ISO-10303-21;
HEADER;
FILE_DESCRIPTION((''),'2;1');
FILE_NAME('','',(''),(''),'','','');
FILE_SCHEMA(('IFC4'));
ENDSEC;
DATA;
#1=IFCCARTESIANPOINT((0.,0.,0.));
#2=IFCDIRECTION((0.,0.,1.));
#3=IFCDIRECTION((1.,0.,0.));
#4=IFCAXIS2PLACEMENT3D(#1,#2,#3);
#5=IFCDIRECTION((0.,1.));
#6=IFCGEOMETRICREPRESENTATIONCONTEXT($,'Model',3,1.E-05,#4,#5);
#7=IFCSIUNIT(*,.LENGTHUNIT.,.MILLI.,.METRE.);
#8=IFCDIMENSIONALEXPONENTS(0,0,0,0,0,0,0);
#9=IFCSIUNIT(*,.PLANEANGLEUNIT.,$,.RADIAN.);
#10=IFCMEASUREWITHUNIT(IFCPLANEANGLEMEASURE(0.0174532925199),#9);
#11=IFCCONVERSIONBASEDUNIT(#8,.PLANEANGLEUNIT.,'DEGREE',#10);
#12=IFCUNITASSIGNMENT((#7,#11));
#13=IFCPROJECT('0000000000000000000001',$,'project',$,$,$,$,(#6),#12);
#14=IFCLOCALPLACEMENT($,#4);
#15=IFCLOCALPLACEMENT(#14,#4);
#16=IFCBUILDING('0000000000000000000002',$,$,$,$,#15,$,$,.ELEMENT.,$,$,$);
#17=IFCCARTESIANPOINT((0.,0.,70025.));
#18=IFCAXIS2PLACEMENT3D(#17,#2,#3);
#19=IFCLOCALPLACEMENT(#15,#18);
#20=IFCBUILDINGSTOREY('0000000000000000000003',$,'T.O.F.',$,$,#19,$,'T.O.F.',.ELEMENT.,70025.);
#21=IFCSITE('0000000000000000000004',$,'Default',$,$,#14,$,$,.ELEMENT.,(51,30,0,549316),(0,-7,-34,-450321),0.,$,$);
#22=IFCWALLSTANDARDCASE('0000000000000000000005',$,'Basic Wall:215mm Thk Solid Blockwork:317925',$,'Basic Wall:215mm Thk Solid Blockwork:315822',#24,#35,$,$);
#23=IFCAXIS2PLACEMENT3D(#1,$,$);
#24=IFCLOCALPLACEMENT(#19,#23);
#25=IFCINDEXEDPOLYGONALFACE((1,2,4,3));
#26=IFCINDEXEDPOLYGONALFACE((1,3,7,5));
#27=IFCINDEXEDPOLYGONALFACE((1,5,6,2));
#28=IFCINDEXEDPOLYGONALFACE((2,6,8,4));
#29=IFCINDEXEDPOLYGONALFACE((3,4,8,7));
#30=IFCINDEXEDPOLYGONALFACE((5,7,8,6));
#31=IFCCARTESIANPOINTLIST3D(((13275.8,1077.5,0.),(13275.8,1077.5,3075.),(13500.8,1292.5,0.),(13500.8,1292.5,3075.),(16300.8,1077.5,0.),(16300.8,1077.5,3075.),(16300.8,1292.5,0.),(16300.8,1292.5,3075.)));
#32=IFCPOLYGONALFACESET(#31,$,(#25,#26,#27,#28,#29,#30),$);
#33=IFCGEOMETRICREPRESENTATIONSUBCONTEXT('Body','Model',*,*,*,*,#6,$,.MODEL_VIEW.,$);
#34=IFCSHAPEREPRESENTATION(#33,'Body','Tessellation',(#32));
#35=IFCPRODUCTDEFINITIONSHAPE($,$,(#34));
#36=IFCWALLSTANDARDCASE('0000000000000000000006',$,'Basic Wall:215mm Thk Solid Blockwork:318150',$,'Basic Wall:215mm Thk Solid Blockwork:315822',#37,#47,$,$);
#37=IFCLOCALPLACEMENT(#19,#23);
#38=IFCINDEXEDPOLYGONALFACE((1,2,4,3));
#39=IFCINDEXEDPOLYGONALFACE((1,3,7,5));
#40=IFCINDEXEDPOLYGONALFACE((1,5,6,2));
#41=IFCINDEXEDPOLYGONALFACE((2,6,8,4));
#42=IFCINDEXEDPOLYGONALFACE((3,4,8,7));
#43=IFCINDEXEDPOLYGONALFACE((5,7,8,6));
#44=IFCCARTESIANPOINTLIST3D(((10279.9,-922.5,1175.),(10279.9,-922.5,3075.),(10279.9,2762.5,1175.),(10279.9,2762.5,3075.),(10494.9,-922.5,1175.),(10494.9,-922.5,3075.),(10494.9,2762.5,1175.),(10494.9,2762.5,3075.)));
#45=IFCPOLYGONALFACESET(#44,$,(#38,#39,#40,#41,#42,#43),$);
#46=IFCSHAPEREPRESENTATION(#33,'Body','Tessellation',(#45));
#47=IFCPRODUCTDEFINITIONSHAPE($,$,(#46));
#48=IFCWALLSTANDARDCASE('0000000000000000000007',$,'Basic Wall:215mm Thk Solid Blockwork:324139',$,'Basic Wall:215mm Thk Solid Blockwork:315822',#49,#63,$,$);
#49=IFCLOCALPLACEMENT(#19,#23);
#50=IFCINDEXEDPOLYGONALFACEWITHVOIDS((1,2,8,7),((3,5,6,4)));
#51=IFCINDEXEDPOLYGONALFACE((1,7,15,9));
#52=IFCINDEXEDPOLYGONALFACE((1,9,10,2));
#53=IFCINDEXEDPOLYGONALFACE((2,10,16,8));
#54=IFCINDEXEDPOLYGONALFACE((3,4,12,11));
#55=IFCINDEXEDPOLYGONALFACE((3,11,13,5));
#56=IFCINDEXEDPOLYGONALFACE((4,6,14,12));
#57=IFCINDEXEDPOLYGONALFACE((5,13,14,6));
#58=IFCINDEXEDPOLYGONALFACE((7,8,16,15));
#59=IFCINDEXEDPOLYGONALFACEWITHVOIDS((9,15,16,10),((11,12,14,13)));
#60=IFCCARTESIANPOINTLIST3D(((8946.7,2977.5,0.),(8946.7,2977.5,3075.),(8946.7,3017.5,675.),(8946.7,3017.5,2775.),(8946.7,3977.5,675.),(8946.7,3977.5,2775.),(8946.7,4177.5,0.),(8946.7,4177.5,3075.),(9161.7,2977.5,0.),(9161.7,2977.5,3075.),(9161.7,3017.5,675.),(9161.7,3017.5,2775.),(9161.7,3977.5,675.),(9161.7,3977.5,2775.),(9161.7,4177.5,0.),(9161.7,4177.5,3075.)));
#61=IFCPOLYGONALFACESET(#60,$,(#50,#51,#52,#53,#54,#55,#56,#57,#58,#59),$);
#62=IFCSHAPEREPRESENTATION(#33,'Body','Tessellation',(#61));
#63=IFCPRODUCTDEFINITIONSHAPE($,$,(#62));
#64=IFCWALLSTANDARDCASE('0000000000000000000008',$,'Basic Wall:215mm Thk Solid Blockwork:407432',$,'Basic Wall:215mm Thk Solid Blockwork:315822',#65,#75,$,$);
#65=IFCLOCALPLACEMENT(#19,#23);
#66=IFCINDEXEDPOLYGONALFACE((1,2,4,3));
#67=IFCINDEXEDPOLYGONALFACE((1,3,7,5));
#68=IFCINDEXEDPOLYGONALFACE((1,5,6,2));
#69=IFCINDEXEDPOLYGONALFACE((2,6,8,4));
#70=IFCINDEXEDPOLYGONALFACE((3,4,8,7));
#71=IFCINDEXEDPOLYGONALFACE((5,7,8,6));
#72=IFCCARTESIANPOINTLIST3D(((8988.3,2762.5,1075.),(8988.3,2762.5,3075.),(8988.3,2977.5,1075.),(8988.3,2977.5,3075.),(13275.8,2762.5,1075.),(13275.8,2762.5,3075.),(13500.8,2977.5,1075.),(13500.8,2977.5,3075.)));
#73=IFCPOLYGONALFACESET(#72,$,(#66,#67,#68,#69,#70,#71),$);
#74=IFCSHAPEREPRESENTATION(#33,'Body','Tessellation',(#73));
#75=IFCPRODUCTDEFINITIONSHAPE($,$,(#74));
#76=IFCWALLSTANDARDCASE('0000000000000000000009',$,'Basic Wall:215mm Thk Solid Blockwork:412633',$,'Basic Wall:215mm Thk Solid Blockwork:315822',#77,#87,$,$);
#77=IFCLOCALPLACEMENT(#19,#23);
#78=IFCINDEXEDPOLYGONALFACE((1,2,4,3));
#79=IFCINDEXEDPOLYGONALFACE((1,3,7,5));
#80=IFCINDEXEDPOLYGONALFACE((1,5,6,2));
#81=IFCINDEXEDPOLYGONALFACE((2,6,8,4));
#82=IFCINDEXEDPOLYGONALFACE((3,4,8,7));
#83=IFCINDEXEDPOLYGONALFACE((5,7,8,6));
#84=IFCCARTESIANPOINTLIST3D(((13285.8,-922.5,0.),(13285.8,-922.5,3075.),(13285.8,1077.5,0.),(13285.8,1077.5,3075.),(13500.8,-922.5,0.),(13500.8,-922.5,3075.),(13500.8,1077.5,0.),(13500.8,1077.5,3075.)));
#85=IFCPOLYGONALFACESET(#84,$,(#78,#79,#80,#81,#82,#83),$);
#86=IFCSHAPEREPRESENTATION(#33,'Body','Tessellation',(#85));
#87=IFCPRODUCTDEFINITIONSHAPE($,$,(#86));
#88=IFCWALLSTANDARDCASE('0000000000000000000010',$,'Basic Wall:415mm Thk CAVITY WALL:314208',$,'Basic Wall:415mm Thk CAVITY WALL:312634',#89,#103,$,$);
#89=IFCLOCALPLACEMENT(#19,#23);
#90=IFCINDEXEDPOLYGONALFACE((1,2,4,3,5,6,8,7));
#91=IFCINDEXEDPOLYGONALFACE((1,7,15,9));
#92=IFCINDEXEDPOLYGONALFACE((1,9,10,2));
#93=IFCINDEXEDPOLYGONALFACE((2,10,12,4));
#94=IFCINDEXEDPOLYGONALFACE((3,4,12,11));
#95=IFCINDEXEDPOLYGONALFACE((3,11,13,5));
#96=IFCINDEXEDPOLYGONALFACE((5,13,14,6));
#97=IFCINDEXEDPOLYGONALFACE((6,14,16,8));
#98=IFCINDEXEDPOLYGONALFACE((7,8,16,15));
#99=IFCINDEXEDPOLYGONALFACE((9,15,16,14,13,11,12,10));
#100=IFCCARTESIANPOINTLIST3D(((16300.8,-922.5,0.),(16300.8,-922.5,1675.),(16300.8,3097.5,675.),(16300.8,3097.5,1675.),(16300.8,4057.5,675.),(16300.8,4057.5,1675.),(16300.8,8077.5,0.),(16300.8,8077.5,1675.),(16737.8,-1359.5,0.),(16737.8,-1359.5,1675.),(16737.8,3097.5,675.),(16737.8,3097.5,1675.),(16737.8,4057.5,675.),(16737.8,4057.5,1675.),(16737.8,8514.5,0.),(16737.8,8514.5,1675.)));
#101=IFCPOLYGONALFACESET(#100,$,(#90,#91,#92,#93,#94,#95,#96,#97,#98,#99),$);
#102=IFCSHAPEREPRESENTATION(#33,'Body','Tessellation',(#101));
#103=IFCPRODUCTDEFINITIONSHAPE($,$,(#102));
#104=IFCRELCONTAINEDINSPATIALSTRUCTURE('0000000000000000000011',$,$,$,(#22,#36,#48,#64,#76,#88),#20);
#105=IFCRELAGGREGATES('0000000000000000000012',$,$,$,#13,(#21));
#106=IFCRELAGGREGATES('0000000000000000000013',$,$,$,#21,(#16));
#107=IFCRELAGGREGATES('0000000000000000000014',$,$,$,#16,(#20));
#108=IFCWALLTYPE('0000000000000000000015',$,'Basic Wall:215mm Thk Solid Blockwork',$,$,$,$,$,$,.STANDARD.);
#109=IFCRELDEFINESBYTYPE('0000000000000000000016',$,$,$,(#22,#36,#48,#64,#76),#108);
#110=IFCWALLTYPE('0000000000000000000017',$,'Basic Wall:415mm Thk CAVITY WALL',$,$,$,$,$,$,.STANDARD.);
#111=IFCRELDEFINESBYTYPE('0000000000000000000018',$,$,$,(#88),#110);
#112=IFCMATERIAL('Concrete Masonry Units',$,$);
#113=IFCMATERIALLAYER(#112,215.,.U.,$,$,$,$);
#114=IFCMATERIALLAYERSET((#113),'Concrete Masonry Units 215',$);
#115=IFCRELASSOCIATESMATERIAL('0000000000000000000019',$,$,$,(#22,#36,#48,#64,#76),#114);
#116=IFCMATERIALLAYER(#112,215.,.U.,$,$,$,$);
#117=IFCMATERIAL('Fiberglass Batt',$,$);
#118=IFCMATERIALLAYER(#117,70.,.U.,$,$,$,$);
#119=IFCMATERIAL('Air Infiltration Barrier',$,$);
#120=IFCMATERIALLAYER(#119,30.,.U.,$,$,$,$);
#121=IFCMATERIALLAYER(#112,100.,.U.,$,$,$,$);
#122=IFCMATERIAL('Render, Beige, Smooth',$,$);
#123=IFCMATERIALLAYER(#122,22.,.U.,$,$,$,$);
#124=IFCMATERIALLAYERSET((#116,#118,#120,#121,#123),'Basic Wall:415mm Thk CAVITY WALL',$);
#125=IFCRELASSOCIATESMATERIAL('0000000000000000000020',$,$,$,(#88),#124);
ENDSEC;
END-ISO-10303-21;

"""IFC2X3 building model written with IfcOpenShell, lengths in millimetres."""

from ifc_helpers import new_model, entity, si_unit, converted_unit, direction, frame, origin_with_axes, place, context, subcontext, project, spatial, polyline, outline, extrude, material, layer, layer_set, layer_usage, type_object, element, save


model = new_model("IFC2X3")

# Units and contexts
model_context = context("Model", 3, precision=1e-05, world=origin_with_axes(), true_north=direction((0.0, 1.0)))
body_context = subcontext(model_context, "Body", "Model", "MODEL_VIEW")
ifc_project = project(units=[si_unit("LENGTHUNIT", "METRE", prefix="MILLI"), converted_unit("PLANEANGLEUNIT", "DEGREE", entity("IfcPlaneAngleMeasure", 0.0174532925199), si_unit("PLANEANGLEUNIT", "RADIAN"), dimensions=[0, 0, 0, 0, 0, 0, 0])], contexts=[model_context])

# Site, building, storey
site_placement = place(None, origin_with_axes())
site = spatial("IfcSite", under=ifc_project, at=site_placement, Name="Default", CompositionType="ELEMENT", RefLatitude=(51, 30, 0, 549316), RefLongitude=(0, -7, -34, -450321), RefElevation=0.0)
building_placement = place(site_placement, origin_with_axes())
building = spatial("IfcBuilding", under=site, at=building_placement, CompositionType="ELEMENT")
storey_placement = place(building_placement, frame((0.0, 0.0, 70025.0), z_axis=(0.0, 0.0, 1.0), x_axis=(1.0, 0.0, 0.0)))
storey = spatial("IfcBuildingStorey", under=building, at=storey_placement, Name="T.O.F.", LongName="T.O.F.", CompositionType="ELEMENT", Elevation=70025.0)

# Shared definitions
ifc_material_1 = material(Name="Concrete Masonry Units")
ifc_layer_1 = layer(ifc_material_1, 215.0, ventilated="UNKNOWN")
ifc_layer_set_1 = layer_set([ifc_layer_1], Name="Concrete Masonry Units 215")
wall_type_1 = type_object("IfcWallType", Name="Basic Wall:215mm Thk Solid Blockwork", PredefinedType="STANDARD")

# Walls
ifc_layer_usage_1 = layer_usage(ifc_layer_set_1, "AXIS2", "POSITIVE", -107.5)
wall_1_placement = place(storey_placement, frame((13388.3, 1185.0, 0.0), z_axis=(0.0, 0.0, 1.0), x_axis=(1.0, 0.0, 0.0)))
element("IfcWallStandardCase", 1, at=wall_1_placement, inside=storey, type_object=wall_type_1, material=ifc_layer_usage_1, Name="Basic Wall:215mm Thk Solid Blockwork:317925", ObjectType="Basic Wall:215mm Thk Solid Blockwork:315822", context=body_context, shape_type="SweptSolid", body=[
    extrude(outline(polyline([(-112.5, -107.5), (2912.5, -107.5), (2912.5, 107.5), (112.5, 107.5), (-112.5, -107.5)])), origin_with_axes(), (0.0, 0.0, 1.0), 3075.0),
])
ifc_layer_usage_2 = layer_usage(ifc_layer_set_1, "AXIS2", "POSITIVE", -107.5)
wall_2_placement = place(storey_placement, frame((10387.4, 2870.0, 1175.0), z_axis=(0.0, 0.0, 1.0), x_axis=(0.0, -1.0, 0.0)))
element("IfcWallStandardCase", 2, at=wall_2_placement, inside=storey, type_object=wall_type_1, material=ifc_layer_usage_2, Name="Basic Wall:215mm Thk Solid Blockwork:318150", ObjectType="Basic Wall:215mm Thk Solid Blockwork:315822", context=body_context, shape_type="SweptSolid", body=[
    extrude(outline(polyline([(107.5, -107.5), (3792.5, -107.5), (3792.5, 107.5), (107.5, 107.5), (107.5, -107.5)])), origin_with_axes(), (0.0, 0.0, 1.0), 1900.0),
])

# Wall, opening
ifc_layer_usage_3 = layer_usage(ifc_layer_set_1, "AXIS2", "POSITIVE", -107.5)
wall_3_placement = place(storey_placement, frame((9054.2, 2870.0, 0.0), z_axis=(0.0, 0.0, 1.0), x_axis=(0.0, 1.0, 0.0)))
wall_3 = element("IfcWallStandardCase", 3, at=wall_3_placement, inside=storey, type_object=wall_type_1, material=ifc_layer_usage_3, Name="Basic Wall:215mm Thk Solid Blockwork:324139", ObjectType="Basic Wall:215mm Thk Solid Blockwork:315822", context=body_context, shape_type="SweptSolid", body=[
    extrude(outline(polyline([(107.5, -107.5), (1307.5, -107.5), (1307.5, 107.5), (107.5, 107.5), (107.5, -107.5)])), origin_with_axes(), (0.0, 0.0, 1.0), 3075.0),
])
opening_1_placement = place(wall_3_placement, frame((627.5, 0.0, 675.0), z_axis=(0.0, 0.0, 1.0), x_axis=(1.0, 0.0, 0.0)))
element("IfcOpeningElement", 4, at=opening_1_placement, cuts=wall_3, context=body_context, shape_type="SweptSolid", body=[
    extrude(outline(polyline([(-480.0, 0.0), (-480.0, -2100.0), (480.0, -2100.0), (480.0, 0.0), (-480.0, 0.0)])), frame((0.0, 107.5, 0.0), z_axis=(0.0, -1.0, 0.0), x_axis=(-1.0, 0.0, 0.0)), (0.0, 0.0, 1.0), 215.0),
])

# Walls
ifc_layer_usage_4 = layer_usage(ifc_layer_set_1, "AXIS2", "POSITIVE", -107.5)
wall_4_placement = place(storey_placement, frame((8988.3, 2870.0, 1075.0), z_axis=(0.0, 0.0, 1.0), x_axis=(1.0, 0.0, 0.0)))
element("IfcWallStandardCase", 5, at=wall_4_placement, inside=storey, type_object=wall_type_1, material=ifc_layer_usage_4, Name="Basic Wall:215mm Thk Solid Blockwork:407432", ObjectType="Basic Wall:215mm Thk Solid Blockwork:315822", context=body_context, shape_type="SweptSolid", body=[
    extrude(outline(polyline([(0.0, -107.5), (4287.5, -107.5), (4512.5, 107.5), (0.0, 107.5), (0.0, -107.5)])), origin_with_axes(), (0.0, 0.0, 1.0), 2000.0),
])
ifc_layer_usage_5 = layer_usage(ifc_layer_set_1, "AXIS2", "POSITIVE", -107.5)
wall_5_placement = place(storey_placement, frame((13393.3, 1185.0, 0.0), z_axis=(0.0, 0.0, 1.0), x_axis=(0.0, -1.0, 0.0)))
element("IfcWallStandardCase", 6, at=wall_5_placement, inside=storey, type_object=wall_type_1, material=ifc_layer_usage_5, Name="Basic Wall:215mm Thk Solid Blockwork:412633", ObjectType="Basic Wall:215mm Thk Solid Blockwork:315822", context=body_context, shape_type="SweptSolid", body=[
    extrude(outline(polyline([(107.5, -107.5), (2107.5, -107.5), (2107.5, 107.5), (107.5, 107.5), (107.5, -107.5)])), origin_with_axes(), (0.0, 0.0, 1.0), 3075.0),
])

# Wall, opening
ifc_layer_2 = layer(ifc_material_1, 215.0, ventilated="UNKNOWN")
ifc_material_2 = material(Name="Fiberglass Batt")
ifc_layer_3 = layer(ifc_material_2, 70.0, ventilated="UNKNOWN")
ifc_material_3 = material(Name="Air Infiltration Barrier")
ifc_layer_4 = layer(ifc_material_3, 30.0, ventilated="UNKNOWN")
ifc_layer_5 = layer(ifc_material_1, 100.0, ventilated="UNKNOWN")
ifc_material_4 = material(Name="Render, Beige, Smooth")
ifc_layer_6 = layer(ifc_material_4, 22.0, ventilated="UNKNOWN")
ifc_layer_set_2 = layer_set([ifc_layer_2, ifc_layer_3, ifc_layer_4, ifc_layer_5, ifc_layer_6], Name="Basic Wall:415mm Thk CAVITY WALL")
ifc_layer_usage_6 = layer_usage(ifc_layer_set_2, "AXIS2", "POSITIVE", -218.5)
wall_type_2 = type_object("IfcWallType", Name="Basic Wall:415mm Thk CAVITY WALL", PredefinedType="STANDARD")
wall_6_placement = place(storey_placement, frame((16519.3, 8296.0, 0.0), z_axis=(0.0, 0.0, 1.0), x_axis=(0.0, -1.0, 0.0)))
wall_6 = element("IfcWallStandardCase", 7, at=wall_6_placement, inside=storey, type_object=wall_type_2, material=ifc_layer_usage_6, Name="Basic Wall:415mm Thk CAVITY WALL:314208", ObjectType="Basic Wall:415mm Thk CAVITY WALL:312634", context=body_context, shape_type="SweptSolid", body=[
    extrude(outline(polyline([(218.5, -218.5), (9218.5, -218.5), (9655.5, 218.5), (-218.5, 218.5), (218.5, -218.5)])), origin_with_axes(), (0.0, 0.0, 1.0), 1675.0),
])
opening_2_placement = place(wall_6_placement, frame((4718.5, 0.0, 675.0), z_axis=(0.0, 0.0, 1.0), x_axis=(1.0, 0.0, 0.0)))
element("IfcOpeningElement", 8, at=opening_2_placement, cuts=wall_6, context=body_context, shape_type="SweptSolid", body=[
    extrude(outline(polyline([(480.0, 0.0), (-480.0, 0.0), (-480.0, -2100.0), (480.0, -2100.0), (480.0, 0.0)])), frame((0.0, -1325.2, 0.0), z_axis=(0.0, 1.0, 0.0), x_axis=(1.0, 0.0, 0.0)), (0.0, 0.0, 1.0), 3048.0),
])

save(model, "model.ifc")
